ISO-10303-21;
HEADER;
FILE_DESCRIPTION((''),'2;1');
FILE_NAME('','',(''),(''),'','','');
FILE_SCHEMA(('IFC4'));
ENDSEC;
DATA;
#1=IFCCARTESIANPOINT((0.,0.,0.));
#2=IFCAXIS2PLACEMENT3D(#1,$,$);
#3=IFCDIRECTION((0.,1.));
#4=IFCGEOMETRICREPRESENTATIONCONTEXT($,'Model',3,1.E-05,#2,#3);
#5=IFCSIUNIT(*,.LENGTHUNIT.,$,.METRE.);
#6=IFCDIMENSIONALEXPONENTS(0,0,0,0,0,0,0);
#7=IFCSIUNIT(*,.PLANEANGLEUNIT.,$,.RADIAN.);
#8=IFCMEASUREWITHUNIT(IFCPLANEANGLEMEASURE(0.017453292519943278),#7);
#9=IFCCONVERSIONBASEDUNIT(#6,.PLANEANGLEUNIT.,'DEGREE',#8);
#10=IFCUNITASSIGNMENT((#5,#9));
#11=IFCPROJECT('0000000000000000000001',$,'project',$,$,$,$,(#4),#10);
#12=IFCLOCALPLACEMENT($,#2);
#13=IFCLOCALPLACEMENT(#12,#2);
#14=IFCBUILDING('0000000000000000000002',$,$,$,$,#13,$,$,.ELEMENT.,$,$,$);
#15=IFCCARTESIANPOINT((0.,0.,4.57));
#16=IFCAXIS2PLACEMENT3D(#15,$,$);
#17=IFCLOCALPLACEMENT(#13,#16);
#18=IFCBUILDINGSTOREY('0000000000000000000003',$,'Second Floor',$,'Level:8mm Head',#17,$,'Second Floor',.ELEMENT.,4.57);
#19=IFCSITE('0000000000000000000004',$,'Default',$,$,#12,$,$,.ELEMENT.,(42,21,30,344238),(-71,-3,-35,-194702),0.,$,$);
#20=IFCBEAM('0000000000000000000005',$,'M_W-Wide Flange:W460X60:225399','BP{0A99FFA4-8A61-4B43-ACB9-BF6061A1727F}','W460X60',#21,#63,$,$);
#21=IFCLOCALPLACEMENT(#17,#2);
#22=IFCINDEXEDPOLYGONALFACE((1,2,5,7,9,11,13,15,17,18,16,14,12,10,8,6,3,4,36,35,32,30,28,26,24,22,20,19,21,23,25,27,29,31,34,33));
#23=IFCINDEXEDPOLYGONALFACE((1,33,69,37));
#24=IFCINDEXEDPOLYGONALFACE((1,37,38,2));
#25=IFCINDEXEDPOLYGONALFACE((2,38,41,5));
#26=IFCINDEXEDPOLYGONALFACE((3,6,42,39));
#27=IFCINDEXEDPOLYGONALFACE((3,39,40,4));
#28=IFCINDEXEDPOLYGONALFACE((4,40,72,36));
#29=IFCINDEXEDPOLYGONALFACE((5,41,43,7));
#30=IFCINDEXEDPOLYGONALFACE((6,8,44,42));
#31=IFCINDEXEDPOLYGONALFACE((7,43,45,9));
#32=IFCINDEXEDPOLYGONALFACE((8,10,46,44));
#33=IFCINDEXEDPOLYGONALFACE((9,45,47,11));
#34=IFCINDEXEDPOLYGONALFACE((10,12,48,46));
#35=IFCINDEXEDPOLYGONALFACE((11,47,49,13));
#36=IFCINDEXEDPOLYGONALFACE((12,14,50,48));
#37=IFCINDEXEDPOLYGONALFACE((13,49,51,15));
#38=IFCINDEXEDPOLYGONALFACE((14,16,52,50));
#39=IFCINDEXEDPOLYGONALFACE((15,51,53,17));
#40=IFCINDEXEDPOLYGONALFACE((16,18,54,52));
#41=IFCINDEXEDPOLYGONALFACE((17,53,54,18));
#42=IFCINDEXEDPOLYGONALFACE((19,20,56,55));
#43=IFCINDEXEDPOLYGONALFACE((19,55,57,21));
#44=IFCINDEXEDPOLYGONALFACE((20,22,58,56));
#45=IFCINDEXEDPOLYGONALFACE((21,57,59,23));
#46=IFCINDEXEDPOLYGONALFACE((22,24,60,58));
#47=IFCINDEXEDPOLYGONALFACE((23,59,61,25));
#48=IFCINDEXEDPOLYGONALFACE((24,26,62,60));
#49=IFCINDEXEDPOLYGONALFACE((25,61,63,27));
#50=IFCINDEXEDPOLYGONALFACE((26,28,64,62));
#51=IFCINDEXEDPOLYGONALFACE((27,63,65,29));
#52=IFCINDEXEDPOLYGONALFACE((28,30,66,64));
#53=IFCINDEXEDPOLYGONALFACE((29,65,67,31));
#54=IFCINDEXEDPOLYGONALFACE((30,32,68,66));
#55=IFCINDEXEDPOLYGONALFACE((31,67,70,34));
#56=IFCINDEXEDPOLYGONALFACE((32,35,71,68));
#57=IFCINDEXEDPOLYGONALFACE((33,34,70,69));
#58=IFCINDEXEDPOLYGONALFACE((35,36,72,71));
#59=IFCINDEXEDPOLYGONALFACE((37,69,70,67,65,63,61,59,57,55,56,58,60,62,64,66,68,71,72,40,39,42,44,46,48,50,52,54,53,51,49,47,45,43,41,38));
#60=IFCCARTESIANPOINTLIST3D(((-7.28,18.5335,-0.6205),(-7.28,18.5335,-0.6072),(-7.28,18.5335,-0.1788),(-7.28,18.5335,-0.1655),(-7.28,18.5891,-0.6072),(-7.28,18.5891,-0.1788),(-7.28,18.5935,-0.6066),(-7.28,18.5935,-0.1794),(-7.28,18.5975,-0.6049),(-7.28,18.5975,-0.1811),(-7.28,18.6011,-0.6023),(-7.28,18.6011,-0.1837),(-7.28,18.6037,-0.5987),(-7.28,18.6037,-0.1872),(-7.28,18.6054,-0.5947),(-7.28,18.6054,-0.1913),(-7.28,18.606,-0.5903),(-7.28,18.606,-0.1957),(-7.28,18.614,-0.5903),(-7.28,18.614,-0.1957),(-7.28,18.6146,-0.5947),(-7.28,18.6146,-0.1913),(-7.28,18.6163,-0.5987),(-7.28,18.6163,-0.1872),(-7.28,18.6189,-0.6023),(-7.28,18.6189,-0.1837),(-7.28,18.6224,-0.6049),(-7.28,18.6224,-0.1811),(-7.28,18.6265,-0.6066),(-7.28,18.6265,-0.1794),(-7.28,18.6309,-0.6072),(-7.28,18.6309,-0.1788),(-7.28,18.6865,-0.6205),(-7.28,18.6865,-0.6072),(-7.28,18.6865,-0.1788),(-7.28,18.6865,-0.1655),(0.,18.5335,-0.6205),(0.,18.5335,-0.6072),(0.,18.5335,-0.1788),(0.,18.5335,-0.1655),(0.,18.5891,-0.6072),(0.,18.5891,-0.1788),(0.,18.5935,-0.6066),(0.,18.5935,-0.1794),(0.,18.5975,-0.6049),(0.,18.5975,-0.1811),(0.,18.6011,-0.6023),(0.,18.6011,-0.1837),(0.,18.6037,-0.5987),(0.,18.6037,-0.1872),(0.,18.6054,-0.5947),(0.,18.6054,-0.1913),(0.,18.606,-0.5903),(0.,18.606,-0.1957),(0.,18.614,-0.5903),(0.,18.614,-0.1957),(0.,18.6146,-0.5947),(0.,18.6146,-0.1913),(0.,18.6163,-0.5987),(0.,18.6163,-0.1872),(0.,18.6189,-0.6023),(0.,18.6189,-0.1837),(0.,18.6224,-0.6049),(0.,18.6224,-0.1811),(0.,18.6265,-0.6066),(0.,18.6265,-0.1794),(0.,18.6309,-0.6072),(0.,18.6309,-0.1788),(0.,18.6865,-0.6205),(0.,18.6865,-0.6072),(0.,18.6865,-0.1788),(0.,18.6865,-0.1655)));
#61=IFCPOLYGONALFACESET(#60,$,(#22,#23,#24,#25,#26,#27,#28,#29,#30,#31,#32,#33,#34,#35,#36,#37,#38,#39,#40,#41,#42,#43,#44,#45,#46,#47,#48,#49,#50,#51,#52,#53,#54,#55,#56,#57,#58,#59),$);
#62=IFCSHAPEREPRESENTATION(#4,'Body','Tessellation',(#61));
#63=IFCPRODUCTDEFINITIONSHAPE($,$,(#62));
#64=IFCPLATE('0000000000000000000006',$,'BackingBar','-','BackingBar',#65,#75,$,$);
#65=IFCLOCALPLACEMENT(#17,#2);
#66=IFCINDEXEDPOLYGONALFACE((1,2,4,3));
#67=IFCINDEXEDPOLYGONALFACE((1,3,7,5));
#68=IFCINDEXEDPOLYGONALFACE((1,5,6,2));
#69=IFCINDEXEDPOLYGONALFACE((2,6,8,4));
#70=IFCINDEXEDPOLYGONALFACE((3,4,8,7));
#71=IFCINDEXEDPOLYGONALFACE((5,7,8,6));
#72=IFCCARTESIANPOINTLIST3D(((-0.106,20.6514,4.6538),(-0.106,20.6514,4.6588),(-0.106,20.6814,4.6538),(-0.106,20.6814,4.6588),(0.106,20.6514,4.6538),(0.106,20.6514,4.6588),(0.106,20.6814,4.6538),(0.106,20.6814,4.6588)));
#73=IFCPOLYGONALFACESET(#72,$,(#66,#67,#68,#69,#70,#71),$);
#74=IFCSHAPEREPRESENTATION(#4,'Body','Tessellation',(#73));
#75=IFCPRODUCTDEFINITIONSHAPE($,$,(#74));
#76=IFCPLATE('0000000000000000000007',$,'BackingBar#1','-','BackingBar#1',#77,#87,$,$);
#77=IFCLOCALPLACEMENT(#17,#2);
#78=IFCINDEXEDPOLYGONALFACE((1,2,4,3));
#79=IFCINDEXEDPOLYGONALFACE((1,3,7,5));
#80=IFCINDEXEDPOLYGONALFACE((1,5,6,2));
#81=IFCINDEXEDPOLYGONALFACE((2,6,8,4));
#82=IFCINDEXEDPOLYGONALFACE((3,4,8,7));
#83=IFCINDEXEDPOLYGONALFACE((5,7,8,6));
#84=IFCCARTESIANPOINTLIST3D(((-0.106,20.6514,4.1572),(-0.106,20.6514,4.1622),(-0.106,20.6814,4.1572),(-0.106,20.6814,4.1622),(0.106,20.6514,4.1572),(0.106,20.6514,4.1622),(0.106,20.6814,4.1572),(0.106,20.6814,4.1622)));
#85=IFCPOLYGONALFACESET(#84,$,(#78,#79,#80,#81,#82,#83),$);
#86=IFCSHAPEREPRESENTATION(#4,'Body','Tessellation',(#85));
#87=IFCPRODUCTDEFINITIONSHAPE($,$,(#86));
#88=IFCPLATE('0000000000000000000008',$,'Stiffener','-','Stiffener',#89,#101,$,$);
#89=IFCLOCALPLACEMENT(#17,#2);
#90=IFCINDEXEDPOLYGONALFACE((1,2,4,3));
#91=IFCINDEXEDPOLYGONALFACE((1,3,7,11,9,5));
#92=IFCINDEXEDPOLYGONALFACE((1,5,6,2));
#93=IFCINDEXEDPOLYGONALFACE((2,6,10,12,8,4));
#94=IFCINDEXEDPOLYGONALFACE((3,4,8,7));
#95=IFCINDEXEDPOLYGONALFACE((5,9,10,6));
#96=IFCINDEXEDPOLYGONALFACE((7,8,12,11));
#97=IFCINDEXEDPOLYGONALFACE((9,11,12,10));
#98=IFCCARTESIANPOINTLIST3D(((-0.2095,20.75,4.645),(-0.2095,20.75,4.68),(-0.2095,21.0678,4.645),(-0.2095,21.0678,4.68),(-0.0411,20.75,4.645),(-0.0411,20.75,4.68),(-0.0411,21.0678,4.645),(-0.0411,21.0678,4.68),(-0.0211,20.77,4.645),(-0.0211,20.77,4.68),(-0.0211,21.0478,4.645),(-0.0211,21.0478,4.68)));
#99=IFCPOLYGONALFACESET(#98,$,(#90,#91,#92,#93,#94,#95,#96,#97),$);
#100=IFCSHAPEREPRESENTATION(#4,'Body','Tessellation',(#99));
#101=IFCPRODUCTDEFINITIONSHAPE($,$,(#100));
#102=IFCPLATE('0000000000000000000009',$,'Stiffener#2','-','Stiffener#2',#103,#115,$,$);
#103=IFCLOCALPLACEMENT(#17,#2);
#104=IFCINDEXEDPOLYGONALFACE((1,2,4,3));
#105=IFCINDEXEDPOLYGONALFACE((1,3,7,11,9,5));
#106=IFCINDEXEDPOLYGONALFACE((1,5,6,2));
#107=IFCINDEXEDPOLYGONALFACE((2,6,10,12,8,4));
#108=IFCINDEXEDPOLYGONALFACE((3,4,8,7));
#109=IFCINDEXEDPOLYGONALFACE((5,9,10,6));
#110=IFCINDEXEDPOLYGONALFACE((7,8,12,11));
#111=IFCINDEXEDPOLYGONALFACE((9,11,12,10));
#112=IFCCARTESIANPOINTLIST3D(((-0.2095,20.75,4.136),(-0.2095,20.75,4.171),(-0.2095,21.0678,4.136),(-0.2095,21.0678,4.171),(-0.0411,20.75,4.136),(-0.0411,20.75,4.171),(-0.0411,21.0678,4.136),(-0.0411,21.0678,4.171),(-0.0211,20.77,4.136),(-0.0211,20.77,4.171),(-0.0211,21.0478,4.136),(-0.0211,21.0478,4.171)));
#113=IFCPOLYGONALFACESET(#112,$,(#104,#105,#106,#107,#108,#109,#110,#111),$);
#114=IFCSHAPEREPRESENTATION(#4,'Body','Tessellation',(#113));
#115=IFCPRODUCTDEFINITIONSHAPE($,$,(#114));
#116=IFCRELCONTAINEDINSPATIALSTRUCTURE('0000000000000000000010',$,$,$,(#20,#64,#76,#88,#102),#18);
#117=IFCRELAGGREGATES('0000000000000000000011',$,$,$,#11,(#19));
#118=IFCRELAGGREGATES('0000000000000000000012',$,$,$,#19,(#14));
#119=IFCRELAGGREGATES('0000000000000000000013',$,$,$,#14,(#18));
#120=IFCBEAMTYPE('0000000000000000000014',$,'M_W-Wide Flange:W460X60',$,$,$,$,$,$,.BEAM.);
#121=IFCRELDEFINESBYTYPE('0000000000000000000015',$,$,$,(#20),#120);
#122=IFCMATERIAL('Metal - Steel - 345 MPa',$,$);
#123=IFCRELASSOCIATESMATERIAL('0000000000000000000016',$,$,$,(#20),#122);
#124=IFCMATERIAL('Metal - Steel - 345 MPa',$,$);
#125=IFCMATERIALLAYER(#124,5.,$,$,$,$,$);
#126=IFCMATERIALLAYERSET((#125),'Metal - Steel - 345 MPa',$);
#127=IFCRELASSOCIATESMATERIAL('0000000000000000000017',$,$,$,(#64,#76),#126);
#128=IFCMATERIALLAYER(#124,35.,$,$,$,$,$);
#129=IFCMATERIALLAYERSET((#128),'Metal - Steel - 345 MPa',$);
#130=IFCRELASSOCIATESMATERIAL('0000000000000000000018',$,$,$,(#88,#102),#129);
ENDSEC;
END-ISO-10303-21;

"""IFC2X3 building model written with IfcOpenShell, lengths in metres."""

from ifc_helpers import new_model, entity, si_unit, converted_unit, direction, frame, origin, origin_with_axes, origin_2d, place, context, project, spatial, polyline, i_section, outline, extrude, material, layer, layer_set, type_object, element, save


model = new_model("IFC2X3")

# Units and contexts
model_context = context("Model", 3, precision=1e-05, world=origin(), true_north=direction((0.0, 1.0)))
ifc_project = project(units=[si_unit("LENGTHUNIT", "METRE"), converted_unit("PLANEANGLEUNIT", "DEGREE", entity("IfcPlaneAngleMeasure", 0.017453292519943278), si_unit("PLANEANGLEUNIT", "RADIAN"), dimensions=[0, 0, 0, 0, 0, 0, 0])], contexts=[model_context])

# Site, building, storey
site_placement = place(None, origin())
site = spatial("IfcSite", under=ifc_project, at=site_placement, Name="Default", CompositionType="ELEMENT", RefLatitude=(42, 21, 30, 344238), RefLongitude=(-71, -3, -35, -194702), RefElevation=0.0)
building_placement = place(site_placement, origin())
building = spatial("IfcBuilding", under=site, at=building_placement, CompositionType="ELEMENT")
storey_placement = place(building_placement, frame((0.0, 0.0, 4.57)))
storey = spatial("IfcBuildingStorey", under=building, at=storey_placement, Name="Second Floor", ObjectType="Level:8mm Head", LongName="Second Floor", CompositionType="ELEMENT", Elevation=4.57)

# Shared definitions
ifc_material_1 = material(Name="Metal - Steel - 345 MPa")

# Beam
beam_type_1 = type_object("IfcBeamType", Name="M_W-Wide Flange:W460X60", PredefinedType="BEAM")
beam_1_placement = place(storey_placement, frame((-7.28, 18.61, -0.393), z_axis=(-1.0, 0.0, 0.0), x_axis=(0.0, -1.0, 0.0)))
element("IfcBeam", 1, at=beam_1_placement, inside=storey, type_object=beam_type_1, material=ifc_material_1, Name="M_W-Wide Flange:W460X60:225399", Description="BP{0A99FFA4-8A61-4B43-ACB9-BF6061A1727F}", ObjectType="W460X60", context=model_context, shape_type="SweptSolid", body=[
    extrude(i_section(OverallWidth=0.153, OverallDepth=0.455, WebThickness=0.008, FlangeThickness=0.0133, FilletRadius=0.0169, at=origin_2d()), origin(), (0.0, 0.0, -1.0), 7.28),
])

# Plates
ifc_material_2 = material(Name="Metal - Steel - 345 MPa")
ifc_layer_1 = layer(ifc_material_2, 5.0)
ifc_layer_set_1 = layer_set([ifc_layer_1], Name="Metal - Steel - 345 MPa")
plate_1_placement = place(storey_placement, frame((0.106, 20.6814, 4.6538), z_axis=(0.0, 0.0, 1.0), x_axis=(-1.0, 0.0, 0.0)))
element("IfcPlate", 2, at=plate_1_placement, inside=storey, material=ifc_layer_set_1, Name="BackingBar", Description="-", ObjectType="BackingBar", context=model_context, shape_type="SweptSolid", body=[
    extrude(outline(polyline([(0.0, 0.0), (0.212, 0.0), (0.212, 0.03), (0.0, 0.03), (0.0, 0.0)])), origin_with_axes(), (0.0, 0.0, 1.0), 0.005),
])
plate_2_placement = place(storey_placement, frame((-0.106, 20.6814, 4.1622), z_axis=(0.0, 0.0, -1.0), x_axis=(1.0, 0.0, 0.0)))
element("IfcPlate", 3, at=plate_2_placement, inside=storey, material=ifc_layer_set_1, Name="BackingBar#1", Description="-", ObjectType="BackingBar#1", context=model_context, shape_type="SweptSolid", body=[
    extrude(outline(polyline([(0.0, 0.0), (0.212, 0.0), (0.212, 0.03), (0.0, 0.03), (0.0, 0.0)])), origin_with_axes(), (0.0, 0.0, 1.0), 0.005),
])

# Plates, openings
ifc_layer_2 = layer(ifc_material_2, 35.0)
ifc_layer_set_2 = layer_set([ifc_layer_2], Name="Metal - Steel - 345 MPa")
plate_3_placement = place(storey_placement, frame((-0.0211, 21.0678, 4.645), z_axis=(0.0, 0.0, 1.0), x_axis=(-1.0, 0.0, 0.0)))
plate_3 = element("IfcPlate", 4, at=plate_3_placement, inside=storey, material=ifc_layer_set_2, Name="Stiffener", Description="-", ObjectType="Stiffener", context=model_context, shape_type="SweptSolid", body=[
    extrude(outline(polyline([(0.0, 0.0), (0.1884, 0.0), (0.1884, 0.3178), (0.0, 0.3178), (0.0, 0.0)])), origin_with_axes(), (0.0, 0.0, 1.0), 0.035),
])
opening_1_placement = place(plate_3_placement, frame((0.0, 0.0, 0.0), z_axis=(0.0, 0.0, 1.0), x_axis=(1.0, 0.0, 0.0)))
element("IfcOpeningElement", 5, at=opening_1_placement, cuts=plate_3, ObjectType="Opening", context=model_context, shape_type="SweptSolid", body=[
    extrude(outline(polyline([(0.0, 0.3178), (0.0, 0.2978), (0.02, 0.3178), (0.0, 0.3178)])), origin(), (0.0, 0.0, 1.0), 0.035),
])
opening_2_placement = place(plate_3_placement, frame((0.0, 0.0, 0.0), z_axis=(0.0, 0.0, 1.0), x_axis=(1.0, 0.0, 0.0)))
element("IfcOpeningElement", 6, at=opening_2_placement, cuts=plate_3, ObjectType="Opening", context=model_context, shape_type="SweptSolid", body=[
    extrude(outline(polyline([(0.0, 0.0), (0.02, 0.0), (0.0, 0.02), (0.0, 0.0)])), origin(), (0.0, 0.0, 1.0), 0.035),
])
plate_4_placement = place(storey_placement, frame((-0.2095, 21.0678, 4.171), z_axis=(0.0, 0.0, -1.0), x_axis=(1.0, 0.0, 0.0)))
plate_4 = element("IfcPlate", 7, at=plate_4_placement, inside=storey, material=ifc_layer_set_2, Name="Stiffener#2", Description="-", ObjectType="Stiffener#2", context=model_context, shape_type="SweptSolid", body=[
    extrude(outline(polyline([(0.0, 0.0), (0.1884, 0.0), (0.1884, 0.3178), (0.0, 0.3178), (0.0, 0.0)])), origin_with_axes(), (0.0, 0.0, 1.0), 0.035),
])
opening_3_placement = place(plate_4_placement, frame((0.0, 0.0, 0.0), z_axis=(0.0, 0.0, 1.0), x_axis=(1.0, 0.0, 0.0)))
element("IfcOpeningElement", 8, at=opening_3_placement, cuts=plate_4, ObjectType="Opening", context=model_context, shape_type="SweptSolid", body=[
    extrude(outline(polyline([(0.1884, 0.3178), (0.1684, 0.3178), (0.1884, 0.2978), (0.1884, 0.3178)])), origin(), (0.0, 0.0, 1.0), 0.035),
])
opening_4_placement = place(plate_4_placement, frame((0.0, 0.0, 0.0), z_axis=(0.0, 0.0, 1.0), x_axis=(1.0, 0.0, 0.0)))
element("IfcOpeningElement", 9, at=opening_4_placement, cuts=plate_4, ObjectType="Opening", context=model_context, shape_type="SweptSolid", body=[
    extrude(outline(polyline([(0.1884, 0.0), (0.1884, 0.02), (0.1684, 0.0), (0.1884, 0.0)])), origin(), (0.0, 0.0, 1.0), 0.035),
])

save(model, "model.ifc")
